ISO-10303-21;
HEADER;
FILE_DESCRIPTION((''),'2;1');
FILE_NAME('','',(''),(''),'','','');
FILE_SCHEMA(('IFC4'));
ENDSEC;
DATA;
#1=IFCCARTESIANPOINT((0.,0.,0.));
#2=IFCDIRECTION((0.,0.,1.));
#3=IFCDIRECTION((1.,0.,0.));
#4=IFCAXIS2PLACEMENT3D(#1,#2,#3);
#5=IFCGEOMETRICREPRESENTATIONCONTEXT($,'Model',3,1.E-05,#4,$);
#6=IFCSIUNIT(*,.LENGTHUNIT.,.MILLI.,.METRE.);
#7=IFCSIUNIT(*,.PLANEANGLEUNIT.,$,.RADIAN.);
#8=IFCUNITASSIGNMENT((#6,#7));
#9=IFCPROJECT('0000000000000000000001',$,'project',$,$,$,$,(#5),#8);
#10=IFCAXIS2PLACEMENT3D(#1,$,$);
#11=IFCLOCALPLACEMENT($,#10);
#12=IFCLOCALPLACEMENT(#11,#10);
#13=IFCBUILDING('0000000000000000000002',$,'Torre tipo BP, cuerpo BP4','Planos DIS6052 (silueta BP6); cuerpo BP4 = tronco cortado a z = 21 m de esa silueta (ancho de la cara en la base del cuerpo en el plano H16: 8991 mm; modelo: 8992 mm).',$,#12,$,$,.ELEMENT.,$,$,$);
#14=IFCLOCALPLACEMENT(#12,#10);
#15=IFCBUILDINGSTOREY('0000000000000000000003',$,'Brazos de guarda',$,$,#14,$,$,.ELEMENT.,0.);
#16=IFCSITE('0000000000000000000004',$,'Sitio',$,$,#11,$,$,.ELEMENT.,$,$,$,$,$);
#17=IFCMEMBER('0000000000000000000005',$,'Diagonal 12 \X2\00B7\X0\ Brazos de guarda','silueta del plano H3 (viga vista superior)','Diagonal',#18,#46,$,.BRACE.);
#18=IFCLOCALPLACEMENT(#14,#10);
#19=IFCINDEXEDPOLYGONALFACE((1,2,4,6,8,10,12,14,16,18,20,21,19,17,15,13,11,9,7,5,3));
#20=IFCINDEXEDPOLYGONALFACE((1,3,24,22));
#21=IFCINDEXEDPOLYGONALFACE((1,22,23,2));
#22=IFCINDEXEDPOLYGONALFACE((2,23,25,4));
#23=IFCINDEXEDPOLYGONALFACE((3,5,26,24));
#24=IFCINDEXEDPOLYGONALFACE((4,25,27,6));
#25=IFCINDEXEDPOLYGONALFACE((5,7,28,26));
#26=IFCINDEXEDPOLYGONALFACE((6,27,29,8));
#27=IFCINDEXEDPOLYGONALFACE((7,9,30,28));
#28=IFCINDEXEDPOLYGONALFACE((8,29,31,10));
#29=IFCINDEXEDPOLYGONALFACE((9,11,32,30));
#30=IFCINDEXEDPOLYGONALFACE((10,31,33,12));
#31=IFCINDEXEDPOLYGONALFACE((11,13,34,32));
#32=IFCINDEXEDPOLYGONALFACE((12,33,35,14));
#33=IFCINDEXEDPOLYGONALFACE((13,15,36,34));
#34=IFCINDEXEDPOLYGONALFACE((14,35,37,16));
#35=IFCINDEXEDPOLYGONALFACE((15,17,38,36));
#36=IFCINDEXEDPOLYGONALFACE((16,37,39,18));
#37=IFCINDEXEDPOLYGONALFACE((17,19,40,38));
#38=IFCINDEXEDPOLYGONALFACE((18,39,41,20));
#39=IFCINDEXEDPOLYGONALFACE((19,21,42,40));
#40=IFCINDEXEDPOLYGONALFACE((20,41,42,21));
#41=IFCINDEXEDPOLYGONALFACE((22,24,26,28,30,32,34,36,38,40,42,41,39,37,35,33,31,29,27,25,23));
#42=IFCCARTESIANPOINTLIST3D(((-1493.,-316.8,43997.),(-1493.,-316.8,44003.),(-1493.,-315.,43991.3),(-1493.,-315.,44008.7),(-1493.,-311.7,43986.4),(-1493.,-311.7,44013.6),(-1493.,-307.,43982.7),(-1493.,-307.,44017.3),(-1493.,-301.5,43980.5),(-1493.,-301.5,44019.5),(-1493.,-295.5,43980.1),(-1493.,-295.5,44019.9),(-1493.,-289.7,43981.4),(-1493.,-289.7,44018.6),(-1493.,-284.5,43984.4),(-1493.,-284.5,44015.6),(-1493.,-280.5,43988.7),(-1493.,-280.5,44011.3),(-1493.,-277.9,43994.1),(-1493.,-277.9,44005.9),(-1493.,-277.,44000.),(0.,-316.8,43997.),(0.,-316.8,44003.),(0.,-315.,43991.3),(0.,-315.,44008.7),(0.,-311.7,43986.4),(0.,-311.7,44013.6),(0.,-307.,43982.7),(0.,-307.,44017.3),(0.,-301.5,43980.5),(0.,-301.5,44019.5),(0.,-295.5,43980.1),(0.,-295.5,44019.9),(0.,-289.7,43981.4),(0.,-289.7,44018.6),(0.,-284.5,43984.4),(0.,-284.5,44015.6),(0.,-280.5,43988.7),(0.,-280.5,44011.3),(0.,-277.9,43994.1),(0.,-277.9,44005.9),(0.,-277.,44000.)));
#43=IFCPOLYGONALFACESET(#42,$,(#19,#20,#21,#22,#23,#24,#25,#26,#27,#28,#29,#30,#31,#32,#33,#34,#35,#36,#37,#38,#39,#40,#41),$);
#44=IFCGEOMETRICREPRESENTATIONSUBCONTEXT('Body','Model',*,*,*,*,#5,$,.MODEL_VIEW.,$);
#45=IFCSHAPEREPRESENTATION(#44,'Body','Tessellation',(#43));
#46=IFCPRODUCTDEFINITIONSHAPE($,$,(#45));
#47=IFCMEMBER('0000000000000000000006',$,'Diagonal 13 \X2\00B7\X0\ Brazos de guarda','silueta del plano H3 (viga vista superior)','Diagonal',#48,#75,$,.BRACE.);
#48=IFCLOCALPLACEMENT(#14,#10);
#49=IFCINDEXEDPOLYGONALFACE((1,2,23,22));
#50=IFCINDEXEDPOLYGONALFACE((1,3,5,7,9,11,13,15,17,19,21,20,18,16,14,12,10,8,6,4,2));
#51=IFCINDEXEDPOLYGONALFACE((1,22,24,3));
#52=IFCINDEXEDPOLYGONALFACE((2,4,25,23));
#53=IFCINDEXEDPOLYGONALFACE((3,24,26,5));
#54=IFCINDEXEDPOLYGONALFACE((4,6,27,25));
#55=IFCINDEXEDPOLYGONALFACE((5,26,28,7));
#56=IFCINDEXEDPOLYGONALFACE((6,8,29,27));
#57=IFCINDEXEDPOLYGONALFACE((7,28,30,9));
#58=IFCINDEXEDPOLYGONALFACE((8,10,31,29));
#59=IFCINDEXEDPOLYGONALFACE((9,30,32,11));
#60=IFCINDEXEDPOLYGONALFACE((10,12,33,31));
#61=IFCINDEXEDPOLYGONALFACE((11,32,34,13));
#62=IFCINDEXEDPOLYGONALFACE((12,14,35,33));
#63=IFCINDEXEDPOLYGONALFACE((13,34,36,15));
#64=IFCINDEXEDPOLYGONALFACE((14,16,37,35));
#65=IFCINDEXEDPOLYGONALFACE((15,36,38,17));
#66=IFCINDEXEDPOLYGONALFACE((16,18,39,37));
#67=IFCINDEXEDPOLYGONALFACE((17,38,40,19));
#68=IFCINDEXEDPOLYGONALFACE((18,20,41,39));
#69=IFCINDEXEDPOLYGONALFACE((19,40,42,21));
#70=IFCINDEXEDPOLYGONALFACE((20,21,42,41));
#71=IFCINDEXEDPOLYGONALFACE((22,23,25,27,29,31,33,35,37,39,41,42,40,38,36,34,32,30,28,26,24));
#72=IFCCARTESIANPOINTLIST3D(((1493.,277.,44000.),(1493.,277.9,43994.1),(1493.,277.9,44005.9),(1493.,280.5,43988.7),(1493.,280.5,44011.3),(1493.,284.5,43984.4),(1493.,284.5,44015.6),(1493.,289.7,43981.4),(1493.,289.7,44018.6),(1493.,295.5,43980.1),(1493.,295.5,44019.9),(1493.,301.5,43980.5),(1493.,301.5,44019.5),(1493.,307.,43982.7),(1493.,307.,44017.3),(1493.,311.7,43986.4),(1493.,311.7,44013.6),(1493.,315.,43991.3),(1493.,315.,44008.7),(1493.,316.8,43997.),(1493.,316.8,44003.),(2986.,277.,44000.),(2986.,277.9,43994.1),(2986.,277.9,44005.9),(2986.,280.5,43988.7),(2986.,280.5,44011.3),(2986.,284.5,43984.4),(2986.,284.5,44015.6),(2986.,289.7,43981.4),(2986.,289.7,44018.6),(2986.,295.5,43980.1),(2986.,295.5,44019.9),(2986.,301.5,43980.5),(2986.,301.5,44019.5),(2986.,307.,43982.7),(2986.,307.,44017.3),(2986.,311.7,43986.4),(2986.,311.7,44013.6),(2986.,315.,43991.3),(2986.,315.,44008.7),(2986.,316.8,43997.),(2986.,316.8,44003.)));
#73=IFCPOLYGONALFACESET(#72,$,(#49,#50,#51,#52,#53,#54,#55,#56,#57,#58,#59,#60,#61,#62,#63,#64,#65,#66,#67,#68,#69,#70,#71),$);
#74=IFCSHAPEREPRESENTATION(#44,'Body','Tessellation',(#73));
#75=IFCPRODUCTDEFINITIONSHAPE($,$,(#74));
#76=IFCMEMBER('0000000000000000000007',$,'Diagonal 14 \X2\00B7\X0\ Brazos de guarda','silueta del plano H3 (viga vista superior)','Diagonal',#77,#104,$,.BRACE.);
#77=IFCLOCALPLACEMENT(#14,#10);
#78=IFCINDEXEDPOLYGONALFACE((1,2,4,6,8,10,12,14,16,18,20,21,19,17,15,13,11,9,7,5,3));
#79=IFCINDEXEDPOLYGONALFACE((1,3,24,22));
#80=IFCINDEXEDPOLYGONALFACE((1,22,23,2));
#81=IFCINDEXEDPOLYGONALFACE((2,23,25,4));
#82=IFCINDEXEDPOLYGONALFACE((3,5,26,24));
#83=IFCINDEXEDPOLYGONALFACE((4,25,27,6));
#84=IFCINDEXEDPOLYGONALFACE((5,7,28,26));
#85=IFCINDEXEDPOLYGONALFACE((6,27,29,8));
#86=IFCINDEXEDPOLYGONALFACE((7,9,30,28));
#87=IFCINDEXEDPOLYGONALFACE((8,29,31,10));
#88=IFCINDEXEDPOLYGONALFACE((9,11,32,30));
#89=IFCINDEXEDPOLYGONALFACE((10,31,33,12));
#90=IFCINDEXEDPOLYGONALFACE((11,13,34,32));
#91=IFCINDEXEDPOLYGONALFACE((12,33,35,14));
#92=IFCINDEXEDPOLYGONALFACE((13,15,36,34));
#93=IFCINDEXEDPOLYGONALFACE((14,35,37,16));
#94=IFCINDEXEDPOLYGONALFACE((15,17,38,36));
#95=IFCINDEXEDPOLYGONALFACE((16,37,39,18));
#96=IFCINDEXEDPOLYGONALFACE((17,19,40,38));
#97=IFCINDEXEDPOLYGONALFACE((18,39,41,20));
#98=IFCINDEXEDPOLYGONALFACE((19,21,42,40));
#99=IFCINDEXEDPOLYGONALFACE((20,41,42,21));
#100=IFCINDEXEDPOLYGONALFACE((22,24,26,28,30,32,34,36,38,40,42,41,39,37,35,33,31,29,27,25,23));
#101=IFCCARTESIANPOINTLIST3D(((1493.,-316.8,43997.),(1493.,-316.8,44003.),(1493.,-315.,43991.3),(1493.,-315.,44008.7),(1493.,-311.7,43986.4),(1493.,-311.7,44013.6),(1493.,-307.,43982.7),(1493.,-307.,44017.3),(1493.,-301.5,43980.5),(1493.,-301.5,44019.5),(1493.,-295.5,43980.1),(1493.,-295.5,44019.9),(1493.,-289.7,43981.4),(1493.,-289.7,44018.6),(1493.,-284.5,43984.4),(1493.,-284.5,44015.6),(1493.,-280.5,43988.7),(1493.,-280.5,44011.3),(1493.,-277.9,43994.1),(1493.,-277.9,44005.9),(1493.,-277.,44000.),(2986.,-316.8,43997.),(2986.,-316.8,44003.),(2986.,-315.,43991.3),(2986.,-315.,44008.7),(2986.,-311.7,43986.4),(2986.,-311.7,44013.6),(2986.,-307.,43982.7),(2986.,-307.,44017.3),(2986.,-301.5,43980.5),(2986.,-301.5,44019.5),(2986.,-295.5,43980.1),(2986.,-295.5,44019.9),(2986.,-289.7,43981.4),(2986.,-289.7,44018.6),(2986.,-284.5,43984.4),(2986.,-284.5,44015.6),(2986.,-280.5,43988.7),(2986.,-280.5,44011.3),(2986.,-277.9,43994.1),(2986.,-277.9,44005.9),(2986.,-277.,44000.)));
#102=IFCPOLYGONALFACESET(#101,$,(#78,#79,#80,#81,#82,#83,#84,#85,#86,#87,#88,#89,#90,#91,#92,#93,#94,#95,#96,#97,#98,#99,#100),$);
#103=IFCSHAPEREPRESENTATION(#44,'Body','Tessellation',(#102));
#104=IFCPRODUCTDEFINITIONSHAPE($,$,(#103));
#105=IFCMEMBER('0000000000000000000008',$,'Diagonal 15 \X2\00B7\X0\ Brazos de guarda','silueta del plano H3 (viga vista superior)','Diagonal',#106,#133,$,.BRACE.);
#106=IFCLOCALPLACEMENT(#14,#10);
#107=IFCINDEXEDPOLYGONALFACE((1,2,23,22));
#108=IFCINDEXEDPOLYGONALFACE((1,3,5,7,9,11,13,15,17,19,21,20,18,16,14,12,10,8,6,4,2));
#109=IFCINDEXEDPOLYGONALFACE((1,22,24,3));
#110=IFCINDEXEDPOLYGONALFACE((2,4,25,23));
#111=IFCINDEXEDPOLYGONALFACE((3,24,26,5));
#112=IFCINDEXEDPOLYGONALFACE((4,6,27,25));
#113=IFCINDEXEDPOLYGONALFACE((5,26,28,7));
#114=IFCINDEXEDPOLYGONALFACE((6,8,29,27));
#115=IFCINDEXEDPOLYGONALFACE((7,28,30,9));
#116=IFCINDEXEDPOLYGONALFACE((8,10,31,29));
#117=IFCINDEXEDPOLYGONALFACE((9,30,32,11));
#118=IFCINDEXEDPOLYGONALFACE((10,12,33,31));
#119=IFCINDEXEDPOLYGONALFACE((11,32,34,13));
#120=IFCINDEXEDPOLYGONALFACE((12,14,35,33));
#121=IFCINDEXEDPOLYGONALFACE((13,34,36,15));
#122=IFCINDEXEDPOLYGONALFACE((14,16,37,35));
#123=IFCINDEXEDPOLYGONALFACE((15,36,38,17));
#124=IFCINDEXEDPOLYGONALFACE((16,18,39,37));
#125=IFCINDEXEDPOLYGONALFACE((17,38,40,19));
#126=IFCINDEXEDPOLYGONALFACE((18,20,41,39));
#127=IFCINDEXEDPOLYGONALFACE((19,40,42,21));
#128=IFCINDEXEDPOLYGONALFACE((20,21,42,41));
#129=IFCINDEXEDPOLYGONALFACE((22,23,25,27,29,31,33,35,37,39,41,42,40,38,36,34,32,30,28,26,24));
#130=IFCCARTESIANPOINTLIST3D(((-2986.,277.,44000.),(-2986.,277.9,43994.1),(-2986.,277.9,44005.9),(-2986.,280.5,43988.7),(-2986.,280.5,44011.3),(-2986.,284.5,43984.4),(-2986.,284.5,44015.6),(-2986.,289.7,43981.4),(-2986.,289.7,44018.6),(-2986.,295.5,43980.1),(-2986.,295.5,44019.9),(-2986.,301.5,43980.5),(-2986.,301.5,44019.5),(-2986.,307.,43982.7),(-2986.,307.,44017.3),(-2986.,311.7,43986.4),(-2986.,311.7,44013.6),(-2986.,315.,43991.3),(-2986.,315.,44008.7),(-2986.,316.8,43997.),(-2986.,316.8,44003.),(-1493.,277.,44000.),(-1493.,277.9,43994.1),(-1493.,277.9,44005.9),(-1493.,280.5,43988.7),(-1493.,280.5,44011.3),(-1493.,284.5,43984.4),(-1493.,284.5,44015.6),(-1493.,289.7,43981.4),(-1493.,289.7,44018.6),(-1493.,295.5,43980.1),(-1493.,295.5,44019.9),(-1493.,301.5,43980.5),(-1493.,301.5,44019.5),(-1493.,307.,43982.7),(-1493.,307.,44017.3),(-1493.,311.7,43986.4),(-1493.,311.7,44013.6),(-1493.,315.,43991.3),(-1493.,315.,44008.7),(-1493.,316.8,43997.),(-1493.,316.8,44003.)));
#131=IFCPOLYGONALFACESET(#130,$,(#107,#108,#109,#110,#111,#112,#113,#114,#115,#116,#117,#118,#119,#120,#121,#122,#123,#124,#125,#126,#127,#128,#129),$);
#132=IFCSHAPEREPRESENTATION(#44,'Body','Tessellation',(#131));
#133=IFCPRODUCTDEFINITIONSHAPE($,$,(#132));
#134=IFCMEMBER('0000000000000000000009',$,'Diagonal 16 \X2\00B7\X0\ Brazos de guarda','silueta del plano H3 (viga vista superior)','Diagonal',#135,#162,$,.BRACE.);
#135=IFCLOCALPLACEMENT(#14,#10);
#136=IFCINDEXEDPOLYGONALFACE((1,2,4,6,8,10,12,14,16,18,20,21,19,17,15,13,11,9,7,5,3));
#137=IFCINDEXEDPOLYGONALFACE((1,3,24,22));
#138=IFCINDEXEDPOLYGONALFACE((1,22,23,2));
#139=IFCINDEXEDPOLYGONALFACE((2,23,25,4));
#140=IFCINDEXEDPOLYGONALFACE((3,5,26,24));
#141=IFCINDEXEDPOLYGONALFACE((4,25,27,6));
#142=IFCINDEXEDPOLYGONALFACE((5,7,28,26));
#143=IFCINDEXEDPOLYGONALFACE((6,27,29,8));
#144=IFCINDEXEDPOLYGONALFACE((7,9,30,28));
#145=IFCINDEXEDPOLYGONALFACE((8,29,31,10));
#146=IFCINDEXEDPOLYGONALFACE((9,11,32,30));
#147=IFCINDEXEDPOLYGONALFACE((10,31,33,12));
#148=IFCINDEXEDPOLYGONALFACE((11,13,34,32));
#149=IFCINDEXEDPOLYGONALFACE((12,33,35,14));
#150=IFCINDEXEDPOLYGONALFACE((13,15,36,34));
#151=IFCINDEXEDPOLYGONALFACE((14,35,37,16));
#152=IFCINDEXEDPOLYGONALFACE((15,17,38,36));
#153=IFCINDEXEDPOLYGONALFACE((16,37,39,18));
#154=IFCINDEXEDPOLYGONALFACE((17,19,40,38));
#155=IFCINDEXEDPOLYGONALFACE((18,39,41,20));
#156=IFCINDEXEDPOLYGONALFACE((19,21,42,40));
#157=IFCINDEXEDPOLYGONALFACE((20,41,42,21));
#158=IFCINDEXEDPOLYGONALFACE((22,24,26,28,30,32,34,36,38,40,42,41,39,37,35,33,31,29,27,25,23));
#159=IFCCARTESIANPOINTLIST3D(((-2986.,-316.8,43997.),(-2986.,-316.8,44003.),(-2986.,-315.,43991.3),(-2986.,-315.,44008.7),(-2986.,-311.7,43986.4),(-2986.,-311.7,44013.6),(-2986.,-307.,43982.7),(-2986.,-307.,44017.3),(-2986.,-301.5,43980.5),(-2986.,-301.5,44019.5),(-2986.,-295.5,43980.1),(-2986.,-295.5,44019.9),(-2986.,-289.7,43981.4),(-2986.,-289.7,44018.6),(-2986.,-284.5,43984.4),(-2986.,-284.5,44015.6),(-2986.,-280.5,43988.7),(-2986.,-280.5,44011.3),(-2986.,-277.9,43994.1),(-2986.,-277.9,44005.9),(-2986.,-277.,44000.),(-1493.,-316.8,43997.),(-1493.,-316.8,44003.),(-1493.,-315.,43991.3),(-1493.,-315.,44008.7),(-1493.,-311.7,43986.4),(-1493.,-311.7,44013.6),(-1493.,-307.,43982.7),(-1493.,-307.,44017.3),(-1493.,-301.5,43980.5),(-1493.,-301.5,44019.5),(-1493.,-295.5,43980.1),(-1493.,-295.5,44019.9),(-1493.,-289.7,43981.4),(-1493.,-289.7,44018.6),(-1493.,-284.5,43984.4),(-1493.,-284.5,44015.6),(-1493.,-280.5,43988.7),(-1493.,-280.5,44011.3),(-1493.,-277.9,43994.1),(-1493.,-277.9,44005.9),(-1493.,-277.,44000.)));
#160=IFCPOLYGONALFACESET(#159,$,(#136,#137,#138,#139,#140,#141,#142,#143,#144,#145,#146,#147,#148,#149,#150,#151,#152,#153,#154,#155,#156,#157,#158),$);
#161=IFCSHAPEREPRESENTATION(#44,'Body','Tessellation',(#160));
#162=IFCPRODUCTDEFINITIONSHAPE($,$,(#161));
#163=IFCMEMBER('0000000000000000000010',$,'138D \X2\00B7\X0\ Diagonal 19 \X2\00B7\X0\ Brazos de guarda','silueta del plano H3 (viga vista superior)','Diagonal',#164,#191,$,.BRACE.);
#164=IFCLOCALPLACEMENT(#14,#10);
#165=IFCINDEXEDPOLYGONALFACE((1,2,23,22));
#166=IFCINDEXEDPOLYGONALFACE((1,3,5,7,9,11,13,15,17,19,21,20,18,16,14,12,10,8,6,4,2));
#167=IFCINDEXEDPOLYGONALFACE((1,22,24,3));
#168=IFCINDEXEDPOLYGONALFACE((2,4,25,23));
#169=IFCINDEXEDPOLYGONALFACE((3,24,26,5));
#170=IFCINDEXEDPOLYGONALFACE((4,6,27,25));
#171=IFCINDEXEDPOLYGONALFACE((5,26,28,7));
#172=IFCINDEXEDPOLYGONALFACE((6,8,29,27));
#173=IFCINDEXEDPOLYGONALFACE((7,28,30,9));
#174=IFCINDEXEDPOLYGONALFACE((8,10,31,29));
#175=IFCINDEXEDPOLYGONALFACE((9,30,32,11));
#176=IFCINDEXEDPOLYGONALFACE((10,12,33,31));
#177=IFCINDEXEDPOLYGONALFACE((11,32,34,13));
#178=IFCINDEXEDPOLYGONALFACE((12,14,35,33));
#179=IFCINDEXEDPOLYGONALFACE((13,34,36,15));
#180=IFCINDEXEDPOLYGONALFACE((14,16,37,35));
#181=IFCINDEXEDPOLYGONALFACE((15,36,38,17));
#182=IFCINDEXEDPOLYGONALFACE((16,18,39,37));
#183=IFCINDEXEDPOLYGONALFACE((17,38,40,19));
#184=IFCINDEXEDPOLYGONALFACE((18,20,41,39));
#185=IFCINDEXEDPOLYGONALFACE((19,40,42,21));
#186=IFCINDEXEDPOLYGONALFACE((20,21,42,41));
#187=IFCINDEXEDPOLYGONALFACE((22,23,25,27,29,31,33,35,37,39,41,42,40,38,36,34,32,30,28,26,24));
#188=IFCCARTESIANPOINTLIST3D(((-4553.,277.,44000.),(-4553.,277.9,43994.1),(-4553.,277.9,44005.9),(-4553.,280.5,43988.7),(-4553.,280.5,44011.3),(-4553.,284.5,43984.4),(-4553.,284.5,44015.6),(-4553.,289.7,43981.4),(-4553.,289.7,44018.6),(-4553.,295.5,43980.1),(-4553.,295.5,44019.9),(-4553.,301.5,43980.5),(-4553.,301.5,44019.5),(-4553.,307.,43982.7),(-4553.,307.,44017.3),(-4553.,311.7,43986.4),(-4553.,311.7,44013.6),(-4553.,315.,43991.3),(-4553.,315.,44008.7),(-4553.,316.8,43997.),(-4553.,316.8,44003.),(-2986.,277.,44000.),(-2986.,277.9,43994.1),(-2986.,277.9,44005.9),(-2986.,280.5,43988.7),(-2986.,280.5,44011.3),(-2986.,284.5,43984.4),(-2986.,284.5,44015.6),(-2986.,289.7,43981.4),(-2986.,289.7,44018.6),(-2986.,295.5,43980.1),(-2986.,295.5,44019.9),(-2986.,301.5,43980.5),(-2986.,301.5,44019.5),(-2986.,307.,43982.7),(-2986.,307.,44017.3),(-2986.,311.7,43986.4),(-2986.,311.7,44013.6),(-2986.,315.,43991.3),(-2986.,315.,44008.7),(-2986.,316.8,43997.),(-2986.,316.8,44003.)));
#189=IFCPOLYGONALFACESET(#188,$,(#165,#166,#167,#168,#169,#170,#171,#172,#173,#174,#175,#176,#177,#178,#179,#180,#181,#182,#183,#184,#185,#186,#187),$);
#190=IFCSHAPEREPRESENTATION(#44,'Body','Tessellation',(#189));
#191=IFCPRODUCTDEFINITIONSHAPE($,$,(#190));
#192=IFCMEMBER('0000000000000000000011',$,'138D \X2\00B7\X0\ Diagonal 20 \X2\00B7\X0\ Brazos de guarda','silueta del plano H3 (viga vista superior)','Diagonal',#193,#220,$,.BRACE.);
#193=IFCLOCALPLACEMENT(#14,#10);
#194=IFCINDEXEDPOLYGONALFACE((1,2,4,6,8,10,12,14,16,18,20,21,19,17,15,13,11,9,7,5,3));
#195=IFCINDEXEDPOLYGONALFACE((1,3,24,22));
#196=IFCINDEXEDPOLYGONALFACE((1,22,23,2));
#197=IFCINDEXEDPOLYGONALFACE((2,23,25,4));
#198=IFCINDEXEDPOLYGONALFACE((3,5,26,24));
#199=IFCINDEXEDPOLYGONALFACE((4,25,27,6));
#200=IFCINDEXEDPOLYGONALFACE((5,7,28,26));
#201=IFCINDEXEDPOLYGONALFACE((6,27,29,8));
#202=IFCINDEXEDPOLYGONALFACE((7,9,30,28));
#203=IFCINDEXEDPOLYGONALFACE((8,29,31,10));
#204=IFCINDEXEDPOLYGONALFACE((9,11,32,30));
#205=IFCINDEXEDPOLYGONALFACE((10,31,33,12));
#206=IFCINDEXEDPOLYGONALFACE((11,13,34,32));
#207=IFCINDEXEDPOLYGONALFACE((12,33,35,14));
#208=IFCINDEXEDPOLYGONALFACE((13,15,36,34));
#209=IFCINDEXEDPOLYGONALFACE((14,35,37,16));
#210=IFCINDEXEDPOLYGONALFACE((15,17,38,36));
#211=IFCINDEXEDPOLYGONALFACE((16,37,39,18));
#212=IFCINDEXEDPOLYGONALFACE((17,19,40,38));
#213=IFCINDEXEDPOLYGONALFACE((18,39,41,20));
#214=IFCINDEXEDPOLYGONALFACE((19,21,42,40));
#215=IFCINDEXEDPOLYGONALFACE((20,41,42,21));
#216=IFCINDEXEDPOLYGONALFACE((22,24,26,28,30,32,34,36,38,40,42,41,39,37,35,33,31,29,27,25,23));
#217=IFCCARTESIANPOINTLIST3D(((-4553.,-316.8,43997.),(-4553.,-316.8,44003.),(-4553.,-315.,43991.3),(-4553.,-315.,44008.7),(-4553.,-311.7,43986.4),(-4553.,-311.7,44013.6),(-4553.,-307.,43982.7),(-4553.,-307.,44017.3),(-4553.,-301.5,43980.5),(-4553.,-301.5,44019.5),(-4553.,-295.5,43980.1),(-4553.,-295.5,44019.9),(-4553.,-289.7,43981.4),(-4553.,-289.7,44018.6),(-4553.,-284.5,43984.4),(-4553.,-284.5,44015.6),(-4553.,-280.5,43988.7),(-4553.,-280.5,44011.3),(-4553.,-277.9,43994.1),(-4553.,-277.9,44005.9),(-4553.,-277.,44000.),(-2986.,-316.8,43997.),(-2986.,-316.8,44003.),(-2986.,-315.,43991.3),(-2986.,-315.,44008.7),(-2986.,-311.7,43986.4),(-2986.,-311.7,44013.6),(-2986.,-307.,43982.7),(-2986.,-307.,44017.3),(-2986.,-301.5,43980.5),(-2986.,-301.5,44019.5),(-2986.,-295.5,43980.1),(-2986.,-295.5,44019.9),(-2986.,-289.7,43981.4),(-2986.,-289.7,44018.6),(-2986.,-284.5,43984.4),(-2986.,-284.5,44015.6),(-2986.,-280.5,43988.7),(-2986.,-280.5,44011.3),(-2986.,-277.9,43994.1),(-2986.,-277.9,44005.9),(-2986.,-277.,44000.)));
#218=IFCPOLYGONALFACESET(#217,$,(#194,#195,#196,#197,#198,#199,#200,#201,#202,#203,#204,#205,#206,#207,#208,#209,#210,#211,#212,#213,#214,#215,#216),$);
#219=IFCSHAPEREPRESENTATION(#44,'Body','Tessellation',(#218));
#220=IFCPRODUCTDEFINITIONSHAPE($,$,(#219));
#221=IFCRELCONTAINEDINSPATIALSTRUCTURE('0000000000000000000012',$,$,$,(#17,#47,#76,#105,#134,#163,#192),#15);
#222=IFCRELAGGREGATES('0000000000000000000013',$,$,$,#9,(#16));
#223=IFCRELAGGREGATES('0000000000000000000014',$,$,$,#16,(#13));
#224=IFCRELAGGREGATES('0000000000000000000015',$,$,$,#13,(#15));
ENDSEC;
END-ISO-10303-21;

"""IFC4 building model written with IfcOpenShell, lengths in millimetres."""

from ifc_helpers import new_model, si_unit, frame, origin, origin_with_axes, place, context, subcontext, project, spatial, circle, extrude, element, save


model = new_model("IFC4")

# Units and contexts
model_context = context("Model", 3, precision=1e-05, world=origin_with_axes())
body_context = subcontext(model_context, "Body", "Model", "MODEL_VIEW")
ifc_project = project(units=[si_unit("LENGTHUNIT", "METRE", prefix="MILLI"), si_unit("PLANEANGLEUNIT", "RADIAN")], contexts=[model_context])

# Site, building, storey
site_placement = place(None, origin())
site = spatial("IfcSite", under=ifc_project, at=site_placement, Name="Sitio", CompositionType="ELEMENT")
building_placement = place(site_placement, origin())
building = spatial("IfcBuilding", under=site, at=building_placement, Name="Torre tipo BP, cuerpo BP4", Description="Planos DIS6052 (silueta BP6); cuerpo BP4 = tronco cortado a z = 21 m de esa silueta (ancho de la cara en la base del cuerpo en el plano H16: 8991 mm; modelo: 8992 mm).", CompositionType="ELEMENT")
storey_placement = place(building_placement, origin())
storey = spatial("IfcBuildingStorey", under=building, at=storey_placement, Name="Brazos de guarda", CompositionType="ELEMENT", Elevation=0.0)

# Members
for number, where, z_axis, x_axis, name in (
    (1, (0.0, -297.0, 44000.0), (-1.0, 0.0, 0.0), (0.0, 1.0, 0.0), "Diagonal 12 · Brazos de guarda"),
    (2, (1493.0, 297.0, 44000.0), (1.0, 0.0, 0.0), (0.0, -1.0, 0.0), "Diagonal 13 · Brazos de guarda"),
    (3, (1493.0, -297.0, 44000.0), (1.0, 0.0, 0.0), (0.0, 1.0, 0.0), "Diagonal 14 · Brazos de guarda"),
    (4, (-1493.0, 297.0, 44000.0), (-1.0, 0.0, 0.0), (0.0, -1.0, 0.0), "Diagonal 15 · Brazos de guarda"),
    (5, (-1493.0, -297.0, 44000.0), (-1.0, 0.0, 0.0), (0.0, 1.0, 0.0), "Diagonal 16 · Brazos de guarda"),
):
    element("IfcMember", number, at=place(storey_placement, frame(where, z_axis=z_axis, x_axis=x_axis)), inside=storey, Name=name, Description="silueta del plano H3 (viga vista superior)", ObjectType="Diagonal", PredefinedType="BRACE", context=body_context, shape_type="SweptSolid", body=[
        extrude(circle(Radius=20.0), None, (0.0, 0.0, 1.0), 1493.0),
    ])
for number, where, z_axis, x_axis, name in (
    (6, (-2986.0, 297.0, 44000.0), (-1.0, 0.0, 0.0), (0.0, -1.0, 0.0), "138D · Diagonal 19 · Brazos de guarda"),
    (7, (-2986.0, -297.0, 44000.0), (-1.0, 0.0, 0.0), (0.0, 1.0, 0.0), "138D · Diagonal 20 · Brazos de guarda"),
):
    element("IfcMember", number, at=place(storey_placement, frame(where, z_axis=z_axis, x_axis=x_axis)), inside=storey, Name=name, Description="silueta del plano H3 (viga vista superior)", ObjectType="Diagonal", PredefinedType="BRACE", context=body_context, shape_type="SweptSolid", body=[
        extrude(circle(Radius=20.0), None, (0.0, 0.0, 1.0), 1567.0),
    ])

save(model, "model.ifc")
